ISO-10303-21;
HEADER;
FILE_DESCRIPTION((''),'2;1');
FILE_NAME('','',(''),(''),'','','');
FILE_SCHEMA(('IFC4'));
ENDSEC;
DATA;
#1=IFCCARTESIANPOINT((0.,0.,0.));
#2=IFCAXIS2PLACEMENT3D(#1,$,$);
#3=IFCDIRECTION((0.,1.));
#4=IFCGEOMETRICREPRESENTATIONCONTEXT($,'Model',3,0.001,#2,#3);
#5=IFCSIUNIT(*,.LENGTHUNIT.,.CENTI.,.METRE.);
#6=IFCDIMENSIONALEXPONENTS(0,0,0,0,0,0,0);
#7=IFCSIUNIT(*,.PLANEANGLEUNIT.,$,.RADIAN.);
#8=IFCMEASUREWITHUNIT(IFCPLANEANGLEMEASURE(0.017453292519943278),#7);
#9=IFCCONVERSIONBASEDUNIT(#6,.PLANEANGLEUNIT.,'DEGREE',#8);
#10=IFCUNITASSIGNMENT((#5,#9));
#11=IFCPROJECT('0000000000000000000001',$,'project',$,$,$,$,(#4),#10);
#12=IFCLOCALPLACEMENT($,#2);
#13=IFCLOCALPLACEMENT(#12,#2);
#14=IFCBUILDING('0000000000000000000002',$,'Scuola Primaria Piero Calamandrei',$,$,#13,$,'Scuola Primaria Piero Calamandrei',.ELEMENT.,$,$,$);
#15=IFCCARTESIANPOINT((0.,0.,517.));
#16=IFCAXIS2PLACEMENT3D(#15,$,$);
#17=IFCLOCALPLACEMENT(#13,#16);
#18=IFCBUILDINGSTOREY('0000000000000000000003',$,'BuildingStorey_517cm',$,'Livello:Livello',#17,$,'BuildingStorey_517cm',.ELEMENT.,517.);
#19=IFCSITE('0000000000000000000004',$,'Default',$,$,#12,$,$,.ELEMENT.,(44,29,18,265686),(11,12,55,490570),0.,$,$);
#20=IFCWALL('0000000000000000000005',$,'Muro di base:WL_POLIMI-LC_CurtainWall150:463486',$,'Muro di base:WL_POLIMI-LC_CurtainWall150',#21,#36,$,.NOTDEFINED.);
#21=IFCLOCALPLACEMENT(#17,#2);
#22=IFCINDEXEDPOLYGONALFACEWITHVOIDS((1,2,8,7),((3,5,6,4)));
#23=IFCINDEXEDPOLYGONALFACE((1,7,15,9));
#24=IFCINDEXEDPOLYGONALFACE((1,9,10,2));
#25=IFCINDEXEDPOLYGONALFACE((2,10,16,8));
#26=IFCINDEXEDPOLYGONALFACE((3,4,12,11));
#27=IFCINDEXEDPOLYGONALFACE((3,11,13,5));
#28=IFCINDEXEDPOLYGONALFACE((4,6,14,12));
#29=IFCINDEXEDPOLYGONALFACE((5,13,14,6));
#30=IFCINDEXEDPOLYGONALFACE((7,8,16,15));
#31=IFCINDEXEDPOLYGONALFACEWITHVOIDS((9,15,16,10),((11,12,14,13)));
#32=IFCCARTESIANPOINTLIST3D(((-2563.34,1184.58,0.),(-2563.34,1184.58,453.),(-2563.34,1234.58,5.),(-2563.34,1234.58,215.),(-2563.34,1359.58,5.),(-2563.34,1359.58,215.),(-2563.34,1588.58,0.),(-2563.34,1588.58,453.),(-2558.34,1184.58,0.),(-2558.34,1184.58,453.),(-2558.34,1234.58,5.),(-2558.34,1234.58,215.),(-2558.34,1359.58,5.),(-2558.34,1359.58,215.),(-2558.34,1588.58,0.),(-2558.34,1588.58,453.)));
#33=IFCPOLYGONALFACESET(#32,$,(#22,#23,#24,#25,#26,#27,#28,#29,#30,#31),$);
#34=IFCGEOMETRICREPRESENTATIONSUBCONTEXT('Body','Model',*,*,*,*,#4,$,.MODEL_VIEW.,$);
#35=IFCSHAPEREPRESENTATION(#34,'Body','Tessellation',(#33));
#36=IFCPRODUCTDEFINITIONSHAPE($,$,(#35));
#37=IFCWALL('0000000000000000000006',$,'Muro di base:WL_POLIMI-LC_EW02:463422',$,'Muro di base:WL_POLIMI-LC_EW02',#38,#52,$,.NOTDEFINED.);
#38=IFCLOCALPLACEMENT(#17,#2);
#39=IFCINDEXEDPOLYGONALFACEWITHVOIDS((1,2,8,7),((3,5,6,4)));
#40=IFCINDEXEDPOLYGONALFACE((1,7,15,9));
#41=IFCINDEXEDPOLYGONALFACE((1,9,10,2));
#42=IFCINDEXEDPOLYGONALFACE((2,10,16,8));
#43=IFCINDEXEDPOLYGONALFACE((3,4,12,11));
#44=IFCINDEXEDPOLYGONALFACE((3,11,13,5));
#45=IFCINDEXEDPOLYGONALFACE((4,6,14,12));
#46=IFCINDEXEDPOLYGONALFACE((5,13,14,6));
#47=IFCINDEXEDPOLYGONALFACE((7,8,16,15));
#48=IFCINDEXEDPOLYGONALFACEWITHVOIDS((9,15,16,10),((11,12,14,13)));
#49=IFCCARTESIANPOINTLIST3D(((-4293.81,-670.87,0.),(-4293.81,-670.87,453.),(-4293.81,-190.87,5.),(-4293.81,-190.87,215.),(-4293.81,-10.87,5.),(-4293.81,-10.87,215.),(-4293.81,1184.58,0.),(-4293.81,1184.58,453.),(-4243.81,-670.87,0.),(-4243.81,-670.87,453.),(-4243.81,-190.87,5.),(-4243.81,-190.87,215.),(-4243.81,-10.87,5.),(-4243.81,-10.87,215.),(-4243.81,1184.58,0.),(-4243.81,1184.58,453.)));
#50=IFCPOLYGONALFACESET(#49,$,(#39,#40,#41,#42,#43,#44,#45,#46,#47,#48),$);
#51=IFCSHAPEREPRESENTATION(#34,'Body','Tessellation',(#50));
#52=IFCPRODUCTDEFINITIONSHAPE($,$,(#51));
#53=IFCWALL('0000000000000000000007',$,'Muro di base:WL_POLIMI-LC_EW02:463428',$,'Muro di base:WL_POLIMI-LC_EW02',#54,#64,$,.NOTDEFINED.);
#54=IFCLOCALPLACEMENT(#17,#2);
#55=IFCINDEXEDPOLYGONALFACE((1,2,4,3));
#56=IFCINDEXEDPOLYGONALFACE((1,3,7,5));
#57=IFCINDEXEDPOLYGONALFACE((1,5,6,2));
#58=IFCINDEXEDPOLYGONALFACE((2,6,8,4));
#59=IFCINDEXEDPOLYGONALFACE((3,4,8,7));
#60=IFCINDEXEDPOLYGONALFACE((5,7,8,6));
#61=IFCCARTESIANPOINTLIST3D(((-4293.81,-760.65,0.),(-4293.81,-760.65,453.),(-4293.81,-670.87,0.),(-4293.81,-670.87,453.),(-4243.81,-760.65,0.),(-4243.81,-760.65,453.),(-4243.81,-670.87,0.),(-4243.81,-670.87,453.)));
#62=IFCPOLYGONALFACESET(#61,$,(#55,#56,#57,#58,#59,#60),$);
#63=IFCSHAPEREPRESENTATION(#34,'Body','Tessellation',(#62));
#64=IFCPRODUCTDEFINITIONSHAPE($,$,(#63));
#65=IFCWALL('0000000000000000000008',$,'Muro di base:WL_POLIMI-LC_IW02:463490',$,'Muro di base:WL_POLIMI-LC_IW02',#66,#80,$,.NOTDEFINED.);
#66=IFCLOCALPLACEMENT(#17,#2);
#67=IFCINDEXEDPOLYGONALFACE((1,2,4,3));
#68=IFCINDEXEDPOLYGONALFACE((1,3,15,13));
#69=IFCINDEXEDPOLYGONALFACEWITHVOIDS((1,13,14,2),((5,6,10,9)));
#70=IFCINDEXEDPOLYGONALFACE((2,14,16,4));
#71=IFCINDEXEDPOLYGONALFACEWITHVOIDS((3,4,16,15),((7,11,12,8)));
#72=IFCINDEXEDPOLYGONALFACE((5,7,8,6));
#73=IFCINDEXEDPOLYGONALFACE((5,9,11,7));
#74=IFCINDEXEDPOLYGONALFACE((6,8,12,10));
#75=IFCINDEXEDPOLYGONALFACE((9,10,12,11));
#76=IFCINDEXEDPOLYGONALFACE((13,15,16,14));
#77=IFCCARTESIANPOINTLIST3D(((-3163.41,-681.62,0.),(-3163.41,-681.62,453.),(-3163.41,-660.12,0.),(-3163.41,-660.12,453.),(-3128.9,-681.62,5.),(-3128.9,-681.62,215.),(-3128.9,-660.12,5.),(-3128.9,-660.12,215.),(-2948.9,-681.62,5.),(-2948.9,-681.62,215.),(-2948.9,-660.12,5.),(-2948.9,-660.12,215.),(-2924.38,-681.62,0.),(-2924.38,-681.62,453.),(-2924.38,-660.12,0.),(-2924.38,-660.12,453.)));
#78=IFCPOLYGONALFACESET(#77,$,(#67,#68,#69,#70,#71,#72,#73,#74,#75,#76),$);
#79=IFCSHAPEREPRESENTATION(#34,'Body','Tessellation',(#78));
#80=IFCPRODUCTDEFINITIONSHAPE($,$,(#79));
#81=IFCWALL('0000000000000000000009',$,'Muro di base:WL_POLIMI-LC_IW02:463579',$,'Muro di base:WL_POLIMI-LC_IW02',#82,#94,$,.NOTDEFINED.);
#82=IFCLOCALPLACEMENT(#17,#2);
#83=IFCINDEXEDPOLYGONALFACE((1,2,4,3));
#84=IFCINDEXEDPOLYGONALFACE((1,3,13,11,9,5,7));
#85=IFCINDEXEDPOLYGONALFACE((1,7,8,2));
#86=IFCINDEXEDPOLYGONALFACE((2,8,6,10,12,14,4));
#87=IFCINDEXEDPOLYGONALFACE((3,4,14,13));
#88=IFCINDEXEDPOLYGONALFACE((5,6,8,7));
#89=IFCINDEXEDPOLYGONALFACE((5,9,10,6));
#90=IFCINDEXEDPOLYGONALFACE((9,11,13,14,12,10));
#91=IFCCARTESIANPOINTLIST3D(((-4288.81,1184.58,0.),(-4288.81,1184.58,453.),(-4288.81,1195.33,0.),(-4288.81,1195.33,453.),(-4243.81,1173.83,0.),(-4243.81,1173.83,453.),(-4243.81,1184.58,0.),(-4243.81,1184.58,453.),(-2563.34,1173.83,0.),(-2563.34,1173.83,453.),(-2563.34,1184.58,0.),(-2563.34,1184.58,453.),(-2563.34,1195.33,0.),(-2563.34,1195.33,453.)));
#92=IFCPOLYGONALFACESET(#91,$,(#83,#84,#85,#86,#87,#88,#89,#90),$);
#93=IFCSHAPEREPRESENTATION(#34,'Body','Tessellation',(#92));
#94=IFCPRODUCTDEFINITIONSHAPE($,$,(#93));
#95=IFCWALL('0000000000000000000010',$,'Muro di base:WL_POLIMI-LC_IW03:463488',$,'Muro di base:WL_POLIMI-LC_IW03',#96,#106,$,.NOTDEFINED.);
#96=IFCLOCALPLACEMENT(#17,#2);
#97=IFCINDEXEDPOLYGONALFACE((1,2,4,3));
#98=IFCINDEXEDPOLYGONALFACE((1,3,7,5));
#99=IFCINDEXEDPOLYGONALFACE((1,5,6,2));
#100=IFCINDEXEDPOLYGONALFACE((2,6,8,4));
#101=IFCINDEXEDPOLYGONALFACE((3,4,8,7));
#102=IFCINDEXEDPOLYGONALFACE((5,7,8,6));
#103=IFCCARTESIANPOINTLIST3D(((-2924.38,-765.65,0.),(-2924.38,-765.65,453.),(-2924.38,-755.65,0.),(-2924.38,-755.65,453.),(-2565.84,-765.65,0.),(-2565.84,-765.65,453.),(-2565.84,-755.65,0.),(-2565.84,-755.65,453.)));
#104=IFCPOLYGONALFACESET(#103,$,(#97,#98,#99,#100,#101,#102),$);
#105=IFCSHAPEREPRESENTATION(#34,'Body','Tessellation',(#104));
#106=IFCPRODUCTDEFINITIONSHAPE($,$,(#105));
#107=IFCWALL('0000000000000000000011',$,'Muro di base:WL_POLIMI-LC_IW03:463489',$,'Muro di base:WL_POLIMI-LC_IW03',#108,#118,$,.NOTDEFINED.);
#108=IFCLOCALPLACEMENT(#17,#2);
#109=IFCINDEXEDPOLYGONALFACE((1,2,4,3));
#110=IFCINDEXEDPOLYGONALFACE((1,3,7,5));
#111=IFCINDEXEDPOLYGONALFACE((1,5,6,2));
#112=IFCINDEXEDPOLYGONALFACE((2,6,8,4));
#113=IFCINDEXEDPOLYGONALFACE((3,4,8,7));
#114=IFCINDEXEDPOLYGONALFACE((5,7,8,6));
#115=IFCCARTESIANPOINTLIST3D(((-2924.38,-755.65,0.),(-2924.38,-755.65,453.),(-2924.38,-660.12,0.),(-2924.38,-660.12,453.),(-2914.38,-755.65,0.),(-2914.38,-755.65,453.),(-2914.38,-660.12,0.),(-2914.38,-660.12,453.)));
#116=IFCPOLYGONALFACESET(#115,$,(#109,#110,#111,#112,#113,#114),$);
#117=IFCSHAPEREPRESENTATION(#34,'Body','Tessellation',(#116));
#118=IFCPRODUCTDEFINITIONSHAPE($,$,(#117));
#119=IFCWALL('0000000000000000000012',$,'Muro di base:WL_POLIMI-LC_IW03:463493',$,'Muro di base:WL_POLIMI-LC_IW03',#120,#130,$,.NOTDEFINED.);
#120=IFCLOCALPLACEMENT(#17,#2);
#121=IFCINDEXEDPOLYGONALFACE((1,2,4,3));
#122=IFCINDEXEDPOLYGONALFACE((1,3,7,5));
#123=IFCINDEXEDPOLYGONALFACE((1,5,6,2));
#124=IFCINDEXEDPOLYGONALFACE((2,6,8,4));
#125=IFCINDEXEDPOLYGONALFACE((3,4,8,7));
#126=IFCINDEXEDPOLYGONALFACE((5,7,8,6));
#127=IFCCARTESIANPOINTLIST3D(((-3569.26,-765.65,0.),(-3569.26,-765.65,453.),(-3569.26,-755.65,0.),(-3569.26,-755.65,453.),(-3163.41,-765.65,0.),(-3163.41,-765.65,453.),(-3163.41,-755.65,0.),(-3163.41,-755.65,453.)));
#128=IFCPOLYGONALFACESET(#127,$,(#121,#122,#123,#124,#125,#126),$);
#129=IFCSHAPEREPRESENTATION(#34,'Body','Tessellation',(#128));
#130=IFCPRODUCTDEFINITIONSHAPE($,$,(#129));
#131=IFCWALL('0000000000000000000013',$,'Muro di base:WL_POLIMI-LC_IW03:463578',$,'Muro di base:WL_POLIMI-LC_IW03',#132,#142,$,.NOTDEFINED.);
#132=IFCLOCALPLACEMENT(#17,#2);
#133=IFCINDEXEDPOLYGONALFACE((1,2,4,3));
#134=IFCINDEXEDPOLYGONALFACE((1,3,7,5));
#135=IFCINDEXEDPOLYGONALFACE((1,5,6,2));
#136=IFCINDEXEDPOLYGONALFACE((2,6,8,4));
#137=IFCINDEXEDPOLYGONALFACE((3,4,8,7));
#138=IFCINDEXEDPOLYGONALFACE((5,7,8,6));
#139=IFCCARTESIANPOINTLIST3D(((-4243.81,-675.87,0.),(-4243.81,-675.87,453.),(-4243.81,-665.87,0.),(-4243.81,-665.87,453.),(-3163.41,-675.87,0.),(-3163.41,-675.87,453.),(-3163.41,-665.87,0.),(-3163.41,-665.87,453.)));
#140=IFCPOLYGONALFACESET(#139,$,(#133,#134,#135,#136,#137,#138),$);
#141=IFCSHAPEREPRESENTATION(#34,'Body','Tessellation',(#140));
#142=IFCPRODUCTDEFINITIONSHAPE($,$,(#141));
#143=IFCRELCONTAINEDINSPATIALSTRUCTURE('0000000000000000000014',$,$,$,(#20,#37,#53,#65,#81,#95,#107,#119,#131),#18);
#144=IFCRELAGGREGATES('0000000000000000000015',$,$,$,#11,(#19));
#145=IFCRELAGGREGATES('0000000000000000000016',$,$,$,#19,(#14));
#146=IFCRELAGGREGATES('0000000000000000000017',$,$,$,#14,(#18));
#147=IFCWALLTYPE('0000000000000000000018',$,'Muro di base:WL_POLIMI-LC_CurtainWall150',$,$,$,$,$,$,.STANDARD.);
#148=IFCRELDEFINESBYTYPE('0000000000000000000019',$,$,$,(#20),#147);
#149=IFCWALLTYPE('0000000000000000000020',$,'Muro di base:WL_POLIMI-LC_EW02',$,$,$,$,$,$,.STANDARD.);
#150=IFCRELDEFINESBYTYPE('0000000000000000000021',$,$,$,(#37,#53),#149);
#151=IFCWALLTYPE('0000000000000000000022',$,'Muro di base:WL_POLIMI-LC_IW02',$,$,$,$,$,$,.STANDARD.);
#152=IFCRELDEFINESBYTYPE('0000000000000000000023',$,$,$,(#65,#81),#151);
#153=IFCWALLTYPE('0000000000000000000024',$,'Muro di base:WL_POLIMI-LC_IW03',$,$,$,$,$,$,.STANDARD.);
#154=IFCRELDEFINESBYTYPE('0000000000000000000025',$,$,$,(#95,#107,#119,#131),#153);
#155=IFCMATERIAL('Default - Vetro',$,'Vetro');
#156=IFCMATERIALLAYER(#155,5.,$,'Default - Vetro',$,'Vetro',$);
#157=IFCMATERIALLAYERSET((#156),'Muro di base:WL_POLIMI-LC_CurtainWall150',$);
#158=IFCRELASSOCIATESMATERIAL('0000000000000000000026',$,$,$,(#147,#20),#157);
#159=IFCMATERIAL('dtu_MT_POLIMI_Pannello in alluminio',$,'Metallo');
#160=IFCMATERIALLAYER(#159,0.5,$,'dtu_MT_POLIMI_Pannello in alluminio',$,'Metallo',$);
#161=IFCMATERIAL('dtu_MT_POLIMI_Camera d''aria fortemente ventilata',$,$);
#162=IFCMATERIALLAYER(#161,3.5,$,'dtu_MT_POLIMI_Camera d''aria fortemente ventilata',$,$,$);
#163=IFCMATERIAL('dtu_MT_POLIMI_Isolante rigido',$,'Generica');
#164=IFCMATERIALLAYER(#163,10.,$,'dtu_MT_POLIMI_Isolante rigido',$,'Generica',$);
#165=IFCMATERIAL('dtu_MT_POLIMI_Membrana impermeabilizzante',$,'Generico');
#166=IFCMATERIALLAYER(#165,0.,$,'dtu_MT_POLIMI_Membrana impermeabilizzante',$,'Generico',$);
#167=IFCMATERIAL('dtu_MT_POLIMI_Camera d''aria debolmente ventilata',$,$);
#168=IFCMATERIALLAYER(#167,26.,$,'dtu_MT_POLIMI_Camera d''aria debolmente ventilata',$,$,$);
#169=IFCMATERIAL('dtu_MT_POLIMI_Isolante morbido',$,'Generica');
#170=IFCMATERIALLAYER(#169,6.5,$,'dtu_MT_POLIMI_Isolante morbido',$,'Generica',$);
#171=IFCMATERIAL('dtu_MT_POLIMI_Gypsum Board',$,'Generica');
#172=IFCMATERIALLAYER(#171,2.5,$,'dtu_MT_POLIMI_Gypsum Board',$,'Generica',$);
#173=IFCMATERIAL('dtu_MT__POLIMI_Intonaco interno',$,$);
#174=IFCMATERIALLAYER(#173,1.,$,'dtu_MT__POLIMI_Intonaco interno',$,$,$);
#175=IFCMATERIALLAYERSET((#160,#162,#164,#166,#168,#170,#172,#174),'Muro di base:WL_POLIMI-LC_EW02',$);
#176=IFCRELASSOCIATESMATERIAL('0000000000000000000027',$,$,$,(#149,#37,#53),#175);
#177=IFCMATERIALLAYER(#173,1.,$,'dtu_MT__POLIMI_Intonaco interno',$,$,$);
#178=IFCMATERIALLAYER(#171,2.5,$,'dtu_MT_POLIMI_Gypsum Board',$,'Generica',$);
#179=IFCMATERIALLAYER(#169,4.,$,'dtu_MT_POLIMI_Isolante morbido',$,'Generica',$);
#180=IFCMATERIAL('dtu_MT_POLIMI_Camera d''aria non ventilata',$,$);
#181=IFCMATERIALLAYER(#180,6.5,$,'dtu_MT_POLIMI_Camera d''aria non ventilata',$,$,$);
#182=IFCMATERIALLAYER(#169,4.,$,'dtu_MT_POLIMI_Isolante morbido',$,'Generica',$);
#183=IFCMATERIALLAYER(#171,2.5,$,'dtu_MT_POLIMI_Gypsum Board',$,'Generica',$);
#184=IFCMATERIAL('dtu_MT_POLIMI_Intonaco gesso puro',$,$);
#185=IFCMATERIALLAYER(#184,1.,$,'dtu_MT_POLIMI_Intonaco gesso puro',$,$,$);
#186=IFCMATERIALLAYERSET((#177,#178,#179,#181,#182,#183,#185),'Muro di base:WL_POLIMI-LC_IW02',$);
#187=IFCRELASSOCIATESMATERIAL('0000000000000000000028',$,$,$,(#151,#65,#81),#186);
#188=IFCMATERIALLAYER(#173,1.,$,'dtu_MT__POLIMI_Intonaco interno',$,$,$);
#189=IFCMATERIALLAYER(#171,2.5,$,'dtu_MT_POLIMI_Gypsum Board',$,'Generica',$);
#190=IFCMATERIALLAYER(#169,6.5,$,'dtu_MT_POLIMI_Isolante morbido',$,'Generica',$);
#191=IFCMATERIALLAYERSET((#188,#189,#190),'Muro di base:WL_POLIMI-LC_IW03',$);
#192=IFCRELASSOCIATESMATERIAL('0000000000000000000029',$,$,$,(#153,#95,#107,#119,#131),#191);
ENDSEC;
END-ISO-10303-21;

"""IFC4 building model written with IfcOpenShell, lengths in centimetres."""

from ifc_helpers import new_model, entity, si_unit, converted_unit, direction, frame, frame_2d, origin, place, context, subcontext, project, spatial, polyline, rectangle, outline, extrude, clip, bounded_halfspace, material, layer, layer_set, layer_usage, type_object, element, save


model = new_model("IFC4")

# Units and contexts
model_context = context("Model", 3, precision=0.001, world=origin(), true_north=direction((0.0, 1.0)))
body_context = subcontext(model_context, "Body", "Model", "MODEL_VIEW")
ifc_project = project(units=[si_unit("LENGTHUNIT", "METRE", prefix="CENTI"), converted_unit("PLANEANGLEUNIT", "DEGREE", entity("IfcPlaneAngleMeasure", 0.017453292519943278), si_unit("PLANEANGLEUNIT", "RADIAN"), dimensions=[0, 0, 0, 0, 0, 0, 0])], contexts=[model_context])

# Site, building, storey
site_placement = place(None, origin())
site = spatial("IfcSite", under=ifc_project, at=site_placement, Name="Default", CompositionType="ELEMENT", RefLatitude=(44, 29, 18, 265686), RefLongitude=(11, 12, 55, 490570), RefElevation=0.0)
building_placement = place(site_placement, origin())
building = spatial("IfcBuilding", under=site, at=building_placement, Name="Scuola Primaria Piero Calamandrei", LongName="Scuola Primaria Piero Calamandrei", CompositionType="ELEMENT")
storey_placement = place(building_placement, frame((0.0, 0.0, 517.0)))
storey = spatial("IfcBuildingStorey", under=building, at=storey_placement, Name="BuildingStorey_517cm", ObjectType="Livello:Livello", LongName="BuildingStorey_517cm", CompositionType="ELEMENT", Elevation=517.0)

# Shared definitions
ifc_material_1 = material(Name="dtu_MT_POLIMI_Isolante rigido", Category="Generica")
ifc_material_2 = material(Name="dtu_MT__POLIMI_Intonaco interno")

# Shared definitions
ifc_material_3 = material(Name="Default - Vetro", Category="Vetro")
ifc_layer_1 = layer(ifc_material_3, 5.0, Name="Default - Vetro", Category="Vetro")
ifc_layer_set_1 = layer_set([ifc_layer_1], Name="Muro di base:WL_POLIMI-LC_CurtainWall150")
wall_type_1 = type_object("IfcWallType", Name="Muro di base:WL_POLIMI-LC_CurtainWall150", PredefinedType="STANDARD", material=ifc_layer_set_1)

# Walls, openings
ifc_layer_usage_1 = layer_usage(ifc_layer_set_1, "AXIS2", "NEGATIVE", 2.5)
wall_1_placement = place(storey_placement, frame((-2560.84, 1184.58, 0.0), z_axis=(0.0, 0.0, 1.0), x_axis=(0.0, 1.0, 0.0)))
wall_1 = element("IfcWall", 1, at=wall_1_placement, inside=storey, type_object=wall_type_1, material=ifc_layer_usage_1, Name="Muro di base:WL_POLIMI-LC_CurtainWall150:463486", ObjectType="Muro di base:WL_POLIMI-LC_CurtainWall150", PredefinedType="NOTDEFINED", context=body_context, shape_type="SweptSolid", body=[
    extrude(rectangle(XDim=404.0, YDim=5.0, at=frame_2d((202.0, 0.0), x_axis=(-1.0, 0.0))), origin(), (0.0, 0.0, 1.0), 453.0),
])
opening_1_placement = place(wall_1_placement, frame((175.0, 2.5, 5.0)))
element("IfcOpeningElement", 2, at=opening_1_placement, cuts=wall_1, PredefinedType="OPENING", context=body_context, shape_type="SweptSolid", body=[
    extrude(rectangle(XDim=210.0, YDim=125.0, at=frame_2d((105.0, 62.5), x_axis=(-1.0, 0.0))), frame((0.0, 0.0, 0.0), z_axis=(0.0, -1.0, 0.0), x_axis=(0.0, 0.0, 1.0)), (0.0, 0.0, 1.0), 5.0),
])
ifc_material_4 = material(Name="dtu_MT_POLIMI_Pannello in alluminio", Category="Metallo")
ifc_layer_2 = layer(ifc_material_4, 0.5, Name="dtu_MT_POLIMI_Pannello in alluminio", Category="Metallo")
ifc_material_5 = material(Name="dtu_MT_POLIMI_Camera d'aria fortemente ventilata")
ifc_layer_3 = layer(ifc_material_5, 3.5, Name="dtu_MT_POLIMI_Camera d'aria fortemente ventilata")
ifc_layer_4 = layer(ifc_material_1, 10.0, Name="dtu_MT_POLIMI_Isolante rigido", Category="Generica")
ifc_material_6 = material(Name="dtu_MT_POLIMI_Membrana impermeabilizzante", Category="Generico")
ifc_layer_5 = layer(ifc_material_6, 0.0, Name="dtu_MT_POLIMI_Membrana impermeabilizzante", Category="Generico")
ifc_material_7 = material(Name="dtu_MT_POLIMI_Camera d'aria debolmente ventilata")
ifc_layer_6 = layer(ifc_material_7, 26.0, Name="dtu_MT_POLIMI_Camera d'aria debolmente ventilata")
ifc_material_8 = material(Name="dtu_MT_POLIMI_Isolante morbido", Category="Generica")
ifc_layer_7 = layer(ifc_material_8, 6.5, Name="dtu_MT_POLIMI_Isolante morbido", Category="Generica")
ifc_material_9 = material(Name="dtu_MT_POLIMI_Gypsum Board", Category="Generica")
ifc_layer_8 = layer(ifc_material_9, 2.5, Name="dtu_MT_POLIMI_Gypsum Board", Category="Generica")
ifc_layer_9 = layer(ifc_material_2, 1.0, Name="dtu_MT__POLIMI_Intonaco interno")
ifc_layer_set_2 = layer_set([ifc_layer_2, ifc_layer_3, ifc_layer_4, ifc_layer_5, ifc_layer_6, ifc_layer_7, ifc_layer_8, ifc_layer_9], Name="Muro di base:WL_POLIMI-LC_EW02")
ifc_layer_usage_2 = layer_usage(ifc_layer_set_2, "AXIS2", "NEGATIVE", 25.0)
wall_type_2 = type_object("IfcWallType", Name="Muro di base:WL_POLIMI-LC_EW02", PredefinedType="STANDARD", material=ifc_layer_set_2)
wall_2_placement = place(storey_placement, frame((-4268.81, -670.87, 0.0), z_axis=(0.0, 0.0, 1.0), x_axis=(0.0, 1.0, 0.0)))
wall_2 = element("IfcWall", 3, at=wall_2_placement, inside=storey, type_object=wall_type_2, material=ifc_layer_usage_2, Name="Muro di base:WL_POLIMI-LC_EW02:463422", ObjectType="Muro di base:WL_POLIMI-LC_EW02", PredefinedType="NOTDEFINED", context=body_context, shape_type="Clipping", body=[
    clip(extrude(rectangle(XDim=1855.45, YDim=50.0, at=frame_2d((927.73, 0.0), x_axis=(-1.0, 0.0))), origin(), (0.0, 0.0, 1.0), 453.0), bounded_halfspace(frame((0.0, -25.0, 453.0), z_axis=(0.0, 0.0, 1.0), x_axis=(0.0, -1.0, 0.0)), False, frame((0.0, -25.0, 453.0)), polyline([(0.0, 0.0), (5.0, 0.0), (1844.7, 0.0), (1855.45, 0.0), (1855.45, 45.0), (1855.45, 50.0), (0.0, 50.0), (0.0, 0.0)]))),
])
opening_2_placement = place(wall_2_placement, frame((480.0, -25.0, 5.0)))
element("IfcOpeningElement", 4, at=opening_2_placement, cuts=wall_2, PredefinedType="OPENING", context=body_context, shape_type="SweptSolid", body=[
    extrude(rectangle(XDim=210.0, YDim=180.0, at=frame_2d((105.0, 90.0), x_axis=(-1.0, 0.0))), frame((0.0, 0.0, 0.0), z_axis=(0.0, 1.0, 0.0), x_axis=(0.0, 0.0, 1.0)), (0.0, 0.0, 1.0), 50.0),
])

# Wall
ifc_layer_usage_3 = layer_usage(ifc_layer_set_2, "AXIS2", "NEGATIVE", 25.0)
wall_3_placement = place(storey_placement, frame((-4268.81, -760.65, 0.0), z_axis=(0.0, 0.0, 1.0), x_axis=(0.0, 1.0, 0.0)))
element("IfcWall", 5, at=wall_3_placement, inside=storey, type_object=wall_type_2, material=ifc_layer_usage_3, Name="Muro di base:WL_POLIMI-LC_EW02:463428", ObjectType="Muro di base:WL_POLIMI-LC_EW02", PredefinedType="NOTDEFINED", context=body_context, shape_type="SweptSolid", body=[
    extrude(rectangle(XDim=89.78, YDim=50.0, at=frame_2d((44.89, 0.0), x_axis=(-1.0, 0.0))), origin(), (0.0, 0.0, 1.0), 453.0),
])

# Wall, opening
ifc_layer_10 = layer(ifc_material_2, 1.0, Name="dtu_MT__POLIMI_Intonaco interno")
ifc_layer_11 = layer(ifc_material_9, 2.5, Name="dtu_MT_POLIMI_Gypsum Board", Category="Generica")
ifc_layer_12 = layer(ifc_material_8, 4.0, Name="dtu_MT_POLIMI_Isolante morbido", Category="Generica")
ifc_material_10 = material(Name="dtu_MT_POLIMI_Camera d'aria non ventilata")
ifc_layer_13 = layer(ifc_material_10, 6.5, Name="dtu_MT_POLIMI_Camera d'aria non ventilata")
ifc_layer_14 = layer(ifc_material_8, 4.0, Name="dtu_MT_POLIMI_Isolante morbido", Category="Generica")
ifc_layer_15 = layer(ifc_material_9, 2.5, Name="dtu_MT_POLIMI_Gypsum Board", Category="Generica")
ifc_material_11 = material(Name="dtu_MT_POLIMI_Intonaco gesso puro")
ifc_layer_16 = layer(ifc_material_11, 1.0, Name="dtu_MT_POLIMI_Intonaco gesso puro")
ifc_layer_set_3 = layer_set([ifc_layer_10, ifc_layer_11, ifc_layer_12, ifc_layer_13, ifc_layer_14, ifc_layer_15, ifc_layer_16], Name="Muro di base:WL_POLIMI-LC_IW02")
ifc_layer_usage_4 = layer_usage(ifc_layer_set_3, "AXIS2", "NEGATIVE", 10.75)
wall_type_3 = type_object("IfcWallType", Name="Muro di base:WL_POLIMI-LC_IW02", PredefinedType="STANDARD", material=ifc_layer_set_3)
wall_4_placement = place(storey_placement, frame((-3163.41, -670.87, 0.0)))
wall_4 = element("IfcWall", 6, at=wall_4_placement, inside=storey, type_object=wall_type_3, material=ifc_layer_usage_4, Name="Muro di base:WL_POLIMI-LC_IW02:463490", ObjectType="Muro di base:WL_POLIMI-LC_IW02", PredefinedType="NOTDEFINED", context=body_context, shape_type="SweptSolid", body=[
    extrude(rectangle(XDim=239.03, YDim=21.5, at=frame_2d((119.52, 0.0), x_axis=(-1.0, 0.0))), origin(), (0.0, 0.0, 1.0), 453.0),
])
opening_3_placement = place(wall_4_placement, frame((214.52, 10.75, 5.0)))
element("IfcOpeningElement", 7, at=opening_3_placement, cuts=wall_4, PredefinedType="OPENING", context=body_context, shape_type="SweptSolid", body=[
    extrude(rectangle(XDim=210.0, YDim=180.0, at=frame_2d((105.0, 90.0), x_axis=(-1.0, 0.0))), frame((0.0, 0.0, 0.0), z_axis=(0.0, -1.0, 0.0), x_axis=(0.0, 0.0, 1.0)), (0.0, 0.0, 1.0), 21.5),
])

# Walls
ifc_layer_usage_5 = layer_usage(ifc_layer_set_3, "AXIS2", "NEGATIVE", 10.75)
wall_5_placement = place(storey_placement, frame((-4288.81, 1184.58, 0.0)))
element("IfcWall", 8, at=wall_5_placement, inside=storey, type_object=wall_type_3, material=ifc_layer_usage_5, Name="Muro di base:WL_POLIMI-LC_IW02:463579", ObjectType="Muro di base:WL_POLIMI-LC_IW02", PredefinedType="NOTDEFINED", context=body_context, shape_type="SweptSolid", body=[
    extrude(outline(polyline([(-10.75, -973.13), (0.0, -973.13), (10.75, -973.13), (10.75, 752.35), (0.0, 752.35), (0.0, 707.35), (-10.75, 707.35), (-10.75, -973.13)])), frame((752.35, 0.0, 0.0), z_axis=(0.0, 0.0, 1.0), x_axis=(0.0, 1.0, 0.0)), (0.0, 0.0, 1.0), 453.0),
])
ifc_layer_17 = layer(ifc_material_2, 1.0, Name="dtu_MT__POLIMI_Intonaco interno")
ifc_layer_18 = layer(ifc_material_9, 2.5, Name="dtu_MT_POLIMI_Gypsum Board", Category="Generica")
ifc_layer_19 = layer(ifc_material_8, 6.5, Name="dtu_MT_POLIMI_Isolante morbido", Category="Generica")
ifc_layer_set_4 = layer_set([ifc_layer_17, ifc_layer_18, ifc_layer_19], Name="Muro di base:WL_POLIMI-LC_IW03")
ifc_layer_usage_6 = layer_usage(ifc_layer_set_4, "AXIS2", "NEGATIVE", 5.0)
wall_type_4 = type_object("IfcWallType", Name="Muro di base:WL_POLIMI-LC_IW03", PredefinedType="STANDARD", material=ifc_layer_set_4)
wall_6_placement = place(storey_placement, frame((-2924.38, -760.65, 0.0)))
element("IfcWall", 9, at=wall_6_placement, inside=storey, type_object=wall_type_4, material=ifc_layer_usage_6, Name="Muro di base:WL_POLIMI-LC_IW03:463488", ObjectType="Muro di base:WL_POLIMI-LC_IW03", PredefinedType="NOTDEFINED", context=body_context, shape_type="SweptSolid", body=[
    extrude(rectangle(XDim=358.55, YDim=10.0, at=frame_2d((179.27, 0.0), x_axis=(-1.0, 0.0))), origin(), (0.0, 0.0, 1.0), 453.0),
])
ifc_layer_usage_7 = layer_usage(ifc_layer_set_4, "AXIS2", "NEGATIVE", 5.0)
wall_7_placement = place(storey_placement, frame((-2919.38, -660.12, 0.0), z_axis=(0.0, 0.0, 1.0), x_axis=(0.0, -1.0, 0.0)))
element("IfcWall", 10, at=wall_7_placement, inside=storey, type_object=wall_type_4, material=ifc_layer_usage_7, Name="Muro di base:WL_POLIMI-LC_IW03:463489", ObjectType="Muro di base:WL_POLIMI-LC_IW03", PredefinedType="NOTDEFINED", context=body_context, shape_type="SweptSolid", body=[
    extrude(rectangle(XDim=95.53, YDim=10.0, at=frame_2d((47.77, 0.0), x_axis=(-1.0, 0.0))), origin(), (0.0, 0.0, 1.0), 453.0),
])
ifc_layer_usage_8 = layer_usage(ifc_layer_set_4, "AXIS2", "NEGATIVE", 5.0)
wall_8_placement = place(storey_placement, frame((-3569.26, -760.65, 0.0)))
element("IfcWall", 11, at=wall_8_placement, inside=storey, type_object=wall_type_4, material=ifc_layer_usage_8, Name="Muro di base:WL_POLIMI-LC_IW03:463493", ObjectType="Muro di base:WL_POLIMI-LC_IW03", PredefinedType="NOTDEFINED", context=body_context, shape_type="SweptSolid", body=[
    extrude(rectangle(XDim=405.84, YDim=10.0, at=frame_2d((202.92, 0.0), x_axis=(-1.0, 0.0))), origin(), (0.0, 0.0, 1.0), 453.0),
])
ifc_layer_usage_9 = layer_usage(ifc_layer_set_4, "AXIS2", "NEGATIVE", 5.0)
wall_9_placement = place(storey_placement, frame((-3163.41, -670.87, 0.0), z_axis=(0.0, 0.0, 1.0), x_axis=(-1.0, 0.0, 0.0)))
element("IfcWall", 12, at=wall_9_placement, inside=storey, type_object=wall_type_4, material=ifc_layer_usage_9, Name="Muro di base:WL_POLIMI-LC_IW03:463578", ObjectType="Muro di base:WL_POLIMI-LC_IW03", PredefinedType="NOTDEFINED", context=body_context, shape_type="SweptSolid", body=[
    extrude(rectangle(XDim=1080.4, YDim=10.0, at=frame_2d((540.2, 0.0), x_axis=(-1.0, 0.0))), origin(), (0.0, 0.0, 1.0), 453.0),
])

save(model, "model.ifc")
